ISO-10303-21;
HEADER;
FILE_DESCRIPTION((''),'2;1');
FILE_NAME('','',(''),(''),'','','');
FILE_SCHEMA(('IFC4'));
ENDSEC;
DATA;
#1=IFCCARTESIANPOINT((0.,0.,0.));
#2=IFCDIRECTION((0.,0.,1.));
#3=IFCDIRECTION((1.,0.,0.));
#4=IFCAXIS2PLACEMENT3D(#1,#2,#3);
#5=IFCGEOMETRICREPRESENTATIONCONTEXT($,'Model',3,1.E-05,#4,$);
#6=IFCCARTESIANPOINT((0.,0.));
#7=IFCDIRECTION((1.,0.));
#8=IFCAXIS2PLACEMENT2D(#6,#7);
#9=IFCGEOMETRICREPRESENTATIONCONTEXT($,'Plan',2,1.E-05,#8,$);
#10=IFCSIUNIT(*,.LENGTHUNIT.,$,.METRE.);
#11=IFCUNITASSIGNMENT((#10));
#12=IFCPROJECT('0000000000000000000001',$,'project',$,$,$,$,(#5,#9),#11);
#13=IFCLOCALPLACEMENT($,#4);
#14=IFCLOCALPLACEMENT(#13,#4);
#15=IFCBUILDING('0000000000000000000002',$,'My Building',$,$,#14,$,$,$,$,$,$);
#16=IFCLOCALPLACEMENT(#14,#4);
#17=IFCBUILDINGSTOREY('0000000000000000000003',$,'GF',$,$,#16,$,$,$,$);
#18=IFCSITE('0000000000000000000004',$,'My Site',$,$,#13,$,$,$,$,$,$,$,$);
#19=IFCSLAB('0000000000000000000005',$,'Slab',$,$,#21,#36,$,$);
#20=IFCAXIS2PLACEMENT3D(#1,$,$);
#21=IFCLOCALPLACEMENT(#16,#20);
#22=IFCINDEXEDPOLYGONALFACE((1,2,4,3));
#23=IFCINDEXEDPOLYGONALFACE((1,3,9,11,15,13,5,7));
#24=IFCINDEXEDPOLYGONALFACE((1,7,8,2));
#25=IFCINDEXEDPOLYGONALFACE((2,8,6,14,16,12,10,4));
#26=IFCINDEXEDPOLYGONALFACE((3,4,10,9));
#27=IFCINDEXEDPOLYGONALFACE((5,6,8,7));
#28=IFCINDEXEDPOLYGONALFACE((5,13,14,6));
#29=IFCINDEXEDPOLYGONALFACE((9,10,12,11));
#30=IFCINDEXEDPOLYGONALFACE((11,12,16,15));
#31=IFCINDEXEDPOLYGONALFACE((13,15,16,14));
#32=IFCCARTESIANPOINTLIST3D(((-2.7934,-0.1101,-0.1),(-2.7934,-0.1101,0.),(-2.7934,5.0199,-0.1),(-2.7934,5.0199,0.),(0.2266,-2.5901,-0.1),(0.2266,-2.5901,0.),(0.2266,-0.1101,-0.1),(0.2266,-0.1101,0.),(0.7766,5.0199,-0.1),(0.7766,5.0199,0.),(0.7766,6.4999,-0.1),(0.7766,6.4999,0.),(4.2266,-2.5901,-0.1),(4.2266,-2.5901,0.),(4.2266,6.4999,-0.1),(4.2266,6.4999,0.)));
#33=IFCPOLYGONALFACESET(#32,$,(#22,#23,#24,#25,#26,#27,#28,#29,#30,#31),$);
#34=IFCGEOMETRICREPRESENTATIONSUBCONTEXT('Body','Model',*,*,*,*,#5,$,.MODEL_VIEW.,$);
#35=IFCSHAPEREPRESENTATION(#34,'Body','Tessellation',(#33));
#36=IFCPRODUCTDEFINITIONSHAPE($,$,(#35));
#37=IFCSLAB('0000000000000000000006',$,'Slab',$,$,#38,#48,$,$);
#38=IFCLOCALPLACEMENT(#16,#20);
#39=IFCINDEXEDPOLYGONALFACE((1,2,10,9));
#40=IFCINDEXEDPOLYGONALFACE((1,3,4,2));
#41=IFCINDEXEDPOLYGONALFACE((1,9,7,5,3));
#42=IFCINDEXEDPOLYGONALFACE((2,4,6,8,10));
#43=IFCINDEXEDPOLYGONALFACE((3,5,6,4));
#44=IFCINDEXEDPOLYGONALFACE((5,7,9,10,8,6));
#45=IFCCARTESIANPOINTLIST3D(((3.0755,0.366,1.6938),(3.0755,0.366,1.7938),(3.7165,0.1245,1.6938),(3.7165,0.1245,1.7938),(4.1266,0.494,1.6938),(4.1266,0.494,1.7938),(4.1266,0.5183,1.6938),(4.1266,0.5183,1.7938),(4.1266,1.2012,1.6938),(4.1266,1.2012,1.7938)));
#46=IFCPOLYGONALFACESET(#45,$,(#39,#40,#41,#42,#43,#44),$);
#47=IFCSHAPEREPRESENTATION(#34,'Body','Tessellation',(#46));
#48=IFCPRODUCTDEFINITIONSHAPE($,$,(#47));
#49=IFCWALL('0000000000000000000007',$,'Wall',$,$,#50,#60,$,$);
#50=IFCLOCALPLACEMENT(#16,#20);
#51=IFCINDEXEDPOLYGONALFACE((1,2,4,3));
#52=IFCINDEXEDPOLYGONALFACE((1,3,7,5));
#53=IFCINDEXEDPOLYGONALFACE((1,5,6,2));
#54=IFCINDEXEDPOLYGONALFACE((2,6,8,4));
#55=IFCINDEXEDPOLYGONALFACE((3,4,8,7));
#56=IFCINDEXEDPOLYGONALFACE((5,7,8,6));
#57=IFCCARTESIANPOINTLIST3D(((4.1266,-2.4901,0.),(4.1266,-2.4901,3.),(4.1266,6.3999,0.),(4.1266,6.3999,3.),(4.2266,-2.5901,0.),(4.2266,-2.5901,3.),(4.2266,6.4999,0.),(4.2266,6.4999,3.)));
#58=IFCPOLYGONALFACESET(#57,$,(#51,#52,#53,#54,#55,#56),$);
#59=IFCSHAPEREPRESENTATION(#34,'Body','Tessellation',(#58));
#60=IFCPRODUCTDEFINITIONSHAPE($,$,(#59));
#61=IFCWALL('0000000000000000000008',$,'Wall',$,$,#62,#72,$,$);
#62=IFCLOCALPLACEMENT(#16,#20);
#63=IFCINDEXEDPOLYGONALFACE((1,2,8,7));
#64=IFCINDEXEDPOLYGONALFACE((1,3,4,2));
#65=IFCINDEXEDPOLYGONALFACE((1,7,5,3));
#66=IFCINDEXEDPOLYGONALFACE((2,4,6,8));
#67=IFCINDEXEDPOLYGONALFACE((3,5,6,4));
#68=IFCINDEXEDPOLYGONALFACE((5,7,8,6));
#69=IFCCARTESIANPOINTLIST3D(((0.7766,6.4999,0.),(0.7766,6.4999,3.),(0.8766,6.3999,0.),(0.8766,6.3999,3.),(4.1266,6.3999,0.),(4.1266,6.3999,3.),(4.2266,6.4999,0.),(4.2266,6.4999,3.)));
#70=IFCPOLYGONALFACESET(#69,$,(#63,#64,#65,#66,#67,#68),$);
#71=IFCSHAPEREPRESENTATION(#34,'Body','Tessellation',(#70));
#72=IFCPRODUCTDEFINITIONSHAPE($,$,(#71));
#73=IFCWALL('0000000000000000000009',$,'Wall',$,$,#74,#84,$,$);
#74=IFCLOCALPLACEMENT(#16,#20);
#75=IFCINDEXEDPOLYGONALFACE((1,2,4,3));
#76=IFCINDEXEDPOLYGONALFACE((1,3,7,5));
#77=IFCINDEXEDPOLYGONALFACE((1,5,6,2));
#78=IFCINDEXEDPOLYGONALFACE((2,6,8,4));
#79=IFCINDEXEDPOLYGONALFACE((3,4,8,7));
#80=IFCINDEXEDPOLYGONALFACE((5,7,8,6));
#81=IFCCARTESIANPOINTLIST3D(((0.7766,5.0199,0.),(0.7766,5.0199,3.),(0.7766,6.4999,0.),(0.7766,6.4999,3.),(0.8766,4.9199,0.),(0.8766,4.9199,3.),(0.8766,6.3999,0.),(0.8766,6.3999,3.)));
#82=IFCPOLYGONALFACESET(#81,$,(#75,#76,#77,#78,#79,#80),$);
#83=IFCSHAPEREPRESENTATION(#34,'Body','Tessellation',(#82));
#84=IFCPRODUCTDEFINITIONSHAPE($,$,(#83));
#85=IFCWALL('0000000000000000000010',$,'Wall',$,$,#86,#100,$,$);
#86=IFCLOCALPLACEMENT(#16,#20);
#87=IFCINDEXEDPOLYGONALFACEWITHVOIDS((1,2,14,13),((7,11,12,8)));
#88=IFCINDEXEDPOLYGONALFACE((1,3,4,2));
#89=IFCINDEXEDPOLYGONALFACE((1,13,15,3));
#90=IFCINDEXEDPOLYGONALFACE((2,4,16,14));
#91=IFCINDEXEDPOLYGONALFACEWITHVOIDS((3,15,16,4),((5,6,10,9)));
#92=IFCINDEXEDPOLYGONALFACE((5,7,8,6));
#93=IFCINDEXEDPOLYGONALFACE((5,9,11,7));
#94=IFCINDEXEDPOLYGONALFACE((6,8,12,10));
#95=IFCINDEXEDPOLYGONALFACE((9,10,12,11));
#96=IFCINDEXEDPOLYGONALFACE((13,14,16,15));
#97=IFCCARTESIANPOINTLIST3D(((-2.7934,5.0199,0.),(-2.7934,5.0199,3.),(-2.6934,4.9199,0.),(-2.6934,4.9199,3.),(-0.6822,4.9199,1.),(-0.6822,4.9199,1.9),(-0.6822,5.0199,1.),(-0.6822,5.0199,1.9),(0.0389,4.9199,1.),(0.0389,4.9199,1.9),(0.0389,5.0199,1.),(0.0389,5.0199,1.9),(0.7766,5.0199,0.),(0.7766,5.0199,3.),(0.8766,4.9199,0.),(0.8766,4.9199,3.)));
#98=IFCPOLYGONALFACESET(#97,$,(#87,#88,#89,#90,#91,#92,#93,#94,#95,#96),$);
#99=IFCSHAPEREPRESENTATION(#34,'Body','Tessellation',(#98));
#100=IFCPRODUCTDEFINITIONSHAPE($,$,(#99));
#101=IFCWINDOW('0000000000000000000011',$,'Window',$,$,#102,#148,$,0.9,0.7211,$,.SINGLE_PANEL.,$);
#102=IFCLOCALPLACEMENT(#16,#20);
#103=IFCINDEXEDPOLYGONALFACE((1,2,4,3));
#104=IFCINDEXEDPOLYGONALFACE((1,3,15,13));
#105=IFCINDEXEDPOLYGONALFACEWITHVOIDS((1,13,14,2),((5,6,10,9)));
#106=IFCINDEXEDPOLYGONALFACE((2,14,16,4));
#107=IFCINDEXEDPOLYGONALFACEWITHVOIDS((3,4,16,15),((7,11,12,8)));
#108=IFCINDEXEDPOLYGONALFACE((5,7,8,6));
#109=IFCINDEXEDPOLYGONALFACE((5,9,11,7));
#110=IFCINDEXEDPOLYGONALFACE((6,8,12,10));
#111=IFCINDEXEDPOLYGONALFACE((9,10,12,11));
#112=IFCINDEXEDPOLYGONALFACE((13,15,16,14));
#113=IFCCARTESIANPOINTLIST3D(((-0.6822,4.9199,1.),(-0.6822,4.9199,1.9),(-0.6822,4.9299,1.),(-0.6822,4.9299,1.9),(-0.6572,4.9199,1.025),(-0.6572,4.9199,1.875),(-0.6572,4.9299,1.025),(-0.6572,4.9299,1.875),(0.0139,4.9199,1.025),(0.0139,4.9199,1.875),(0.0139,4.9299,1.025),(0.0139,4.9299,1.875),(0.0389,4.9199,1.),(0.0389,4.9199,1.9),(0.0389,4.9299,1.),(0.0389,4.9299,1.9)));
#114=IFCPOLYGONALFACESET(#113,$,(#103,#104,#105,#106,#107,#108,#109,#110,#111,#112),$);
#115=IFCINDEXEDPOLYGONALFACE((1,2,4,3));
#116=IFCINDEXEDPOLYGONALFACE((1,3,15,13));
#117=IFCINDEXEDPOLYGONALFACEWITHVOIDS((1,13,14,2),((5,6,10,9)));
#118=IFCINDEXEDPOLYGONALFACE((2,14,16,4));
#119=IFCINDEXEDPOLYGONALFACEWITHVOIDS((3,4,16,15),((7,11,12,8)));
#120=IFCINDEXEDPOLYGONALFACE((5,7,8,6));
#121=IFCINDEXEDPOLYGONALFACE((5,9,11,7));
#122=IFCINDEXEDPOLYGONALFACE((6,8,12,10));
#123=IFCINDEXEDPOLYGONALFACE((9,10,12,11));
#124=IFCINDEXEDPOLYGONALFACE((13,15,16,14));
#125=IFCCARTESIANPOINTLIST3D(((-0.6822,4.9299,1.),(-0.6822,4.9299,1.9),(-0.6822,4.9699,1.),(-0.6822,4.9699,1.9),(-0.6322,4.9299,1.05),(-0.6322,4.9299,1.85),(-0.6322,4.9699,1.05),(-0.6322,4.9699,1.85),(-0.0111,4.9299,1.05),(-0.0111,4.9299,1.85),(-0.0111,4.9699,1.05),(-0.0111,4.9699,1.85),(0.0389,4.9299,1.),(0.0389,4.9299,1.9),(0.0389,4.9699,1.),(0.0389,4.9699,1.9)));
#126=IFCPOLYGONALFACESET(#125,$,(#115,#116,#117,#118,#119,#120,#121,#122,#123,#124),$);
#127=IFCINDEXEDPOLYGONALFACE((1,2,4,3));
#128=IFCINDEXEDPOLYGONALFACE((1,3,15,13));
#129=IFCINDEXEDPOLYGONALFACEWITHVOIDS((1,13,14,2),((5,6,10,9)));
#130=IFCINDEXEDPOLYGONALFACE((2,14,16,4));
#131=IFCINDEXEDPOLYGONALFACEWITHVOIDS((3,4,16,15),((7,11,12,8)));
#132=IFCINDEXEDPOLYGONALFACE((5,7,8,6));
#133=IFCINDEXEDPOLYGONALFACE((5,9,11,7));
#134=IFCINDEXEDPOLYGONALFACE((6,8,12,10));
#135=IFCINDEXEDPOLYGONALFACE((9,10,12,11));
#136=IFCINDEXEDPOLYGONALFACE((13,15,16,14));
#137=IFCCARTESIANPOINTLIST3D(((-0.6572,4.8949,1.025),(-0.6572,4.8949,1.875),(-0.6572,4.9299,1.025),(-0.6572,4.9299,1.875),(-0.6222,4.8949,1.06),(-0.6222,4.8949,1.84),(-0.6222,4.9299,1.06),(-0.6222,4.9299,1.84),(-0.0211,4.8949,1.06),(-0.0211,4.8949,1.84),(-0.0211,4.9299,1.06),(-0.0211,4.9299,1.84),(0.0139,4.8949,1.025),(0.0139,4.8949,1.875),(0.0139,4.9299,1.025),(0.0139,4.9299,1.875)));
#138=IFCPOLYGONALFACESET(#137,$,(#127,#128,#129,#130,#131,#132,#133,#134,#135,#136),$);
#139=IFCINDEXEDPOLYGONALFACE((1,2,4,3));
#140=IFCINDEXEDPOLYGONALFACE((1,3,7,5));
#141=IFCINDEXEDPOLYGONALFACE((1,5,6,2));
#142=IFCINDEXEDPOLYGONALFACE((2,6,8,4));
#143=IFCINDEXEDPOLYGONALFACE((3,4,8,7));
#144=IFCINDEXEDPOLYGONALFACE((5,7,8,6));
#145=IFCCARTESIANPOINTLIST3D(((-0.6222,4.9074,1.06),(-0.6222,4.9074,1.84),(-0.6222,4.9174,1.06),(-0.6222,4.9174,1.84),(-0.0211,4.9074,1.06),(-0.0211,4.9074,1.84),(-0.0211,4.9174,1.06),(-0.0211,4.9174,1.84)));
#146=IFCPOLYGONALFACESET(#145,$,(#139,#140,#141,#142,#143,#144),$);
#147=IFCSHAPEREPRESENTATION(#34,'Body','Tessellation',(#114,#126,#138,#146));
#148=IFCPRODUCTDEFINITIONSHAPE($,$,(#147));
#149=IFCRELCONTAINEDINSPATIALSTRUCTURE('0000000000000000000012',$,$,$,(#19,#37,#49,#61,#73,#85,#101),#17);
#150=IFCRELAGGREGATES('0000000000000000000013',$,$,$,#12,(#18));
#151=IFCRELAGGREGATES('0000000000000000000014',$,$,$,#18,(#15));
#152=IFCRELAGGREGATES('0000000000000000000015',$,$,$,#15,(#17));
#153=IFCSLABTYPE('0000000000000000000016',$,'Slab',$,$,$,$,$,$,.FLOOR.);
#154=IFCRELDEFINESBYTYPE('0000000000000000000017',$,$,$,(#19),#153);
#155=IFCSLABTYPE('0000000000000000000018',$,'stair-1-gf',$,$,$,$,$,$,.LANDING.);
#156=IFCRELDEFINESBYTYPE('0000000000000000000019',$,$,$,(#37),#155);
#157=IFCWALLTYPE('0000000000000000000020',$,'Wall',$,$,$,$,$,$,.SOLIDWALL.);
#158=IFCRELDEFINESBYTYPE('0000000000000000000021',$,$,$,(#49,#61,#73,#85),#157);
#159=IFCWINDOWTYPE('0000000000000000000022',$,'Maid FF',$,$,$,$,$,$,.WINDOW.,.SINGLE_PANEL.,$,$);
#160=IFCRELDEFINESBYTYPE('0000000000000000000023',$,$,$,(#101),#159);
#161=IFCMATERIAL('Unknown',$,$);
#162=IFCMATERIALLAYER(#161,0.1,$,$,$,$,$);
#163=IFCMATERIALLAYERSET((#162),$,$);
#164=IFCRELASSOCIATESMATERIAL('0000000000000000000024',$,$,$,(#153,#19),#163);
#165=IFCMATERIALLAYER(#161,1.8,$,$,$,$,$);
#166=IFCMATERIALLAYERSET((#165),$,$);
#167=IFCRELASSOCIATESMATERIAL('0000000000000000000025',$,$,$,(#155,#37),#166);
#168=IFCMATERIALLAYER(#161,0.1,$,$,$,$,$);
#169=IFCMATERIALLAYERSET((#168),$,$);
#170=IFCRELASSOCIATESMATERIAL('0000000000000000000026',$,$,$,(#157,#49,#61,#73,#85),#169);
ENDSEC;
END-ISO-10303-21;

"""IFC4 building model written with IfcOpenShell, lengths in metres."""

from ifc_helpers import new_model, entity, si_unit, frame, origin_with_axes, origin_2d_with_axis, place, context, subcontext, project, spatial, line, indexed_curve, outline, extrude, shape, source, transform, mapped, material, layer, layer_set, layer_usage, type_object, type_shapes, element, fill, save


model = new_model("IFC4")

# Units and contexts
model_context = context("Model", 3, precision=1e-05, world=origin_with_axes())
plan_context = context("Plan", 2, precision=1e-05, world=origin_2d_with_axis())
body_context_1 = subcontext(model_context, "Body", "Model", "MODEL_VIEW")
body_context_2 = subcontext(plan_context, "Body", "Plan", "PLAN_VIEW")
ifc_project = project(units=[si_unit("LENGTHUNIT", "METRE")], contexts=[model_context, plan_context])

# Site, building, storey
site_placement = place(None, origin_with_axes())
site = spatial("IfcSite", under=ifc_project, at=site_placement, Name="My Site")
building_placement = place(site_placement, origin_with_axes())
building = spatial("IfcBuilding", under=site, at=building_placement, Name="My Building")
storey_placement = place(building_placement, origin_with_axes())
storey = spatial("IfcBuildingStorey", under=building, at=storey_placement, Name="GF")

# Slabs
ifc_material_1 = material(Name="Unknown")
ifc_layer_1 = layer(ifc_material_1, 0.1)
ifc_layer_set_1 = layer_set([ifc_layer_1])
ifc_layer_usage_1 = layer_usage(ifc_layer_set_1, "AXIS3", "POSITIVE", -0.1)
slab_type_1 = type_object("IfcSlabType", Name="Slab", PredefinedType="FLOOR", material=ifc_layer_set_1)
slab_1_placement = place(storey_placement, frame((4.2266, -2.5901, 0.0), z_axis=(0.0, 0.0, 1.0), x_axis=(1.0, 0.0, 0.0)))
element("IfcSlab", 1, at=slab_1_placement, inside=storey, type_object=slab_type_1, material=ifc_layer_usage_1, Name="Slab", context=body_context_1, shape_type="SweptSolid", body=[
    extrude(outline(indexed_curve([(0.0, 0.0), (0.0, 9.09), (-3.45, 9.09), (-3.45, 7.61), (-7.02, 7.61), (-7.02, 2.48), (-4.0, 2.48), (-4.0, 0.0), (0.0, 0.0)])), frame((0.0, 0.0, -0.1), z_axis=(0.0, 0.0, 1.0), x_axis=(1.0, 0.0, 0.0)), (0.0, 0.0, 1.0), 0.1),
])
ifc_layer_2 = layer(ifc_material_1, 1.8)
ifc_layer_set_2 = layer_set([ifc_layer_2])
ifc_layer_usage_2 = layer_usage(ifc_layer_set_2, "AXIS3", "POSITIVE", -0.1)
slab_type_2 = type_object("IfcSlabType", Name="stair-1-gf", PredefinedType="LANDING", material=ifc_layer_set_2)
slab_2_placement = place(storey_placement, frame((4.1266, 0.5183, 1.7938), z_axis=(0.0, 0.0, 1.0), x_axis=(1.0, 0.0, 0.0)))
element("IfcSlab", 2, at=slab_2_placement, inside=storey, type_object=slab_type_2, material=ifc_layer_usage_2, Name="Slab", context=body_context_1, shape_type="SweptSolid", body=[
    extrude(outline(indexed_curve([(0.0, 0.0), (0.0, 0.6829), (-1.0511, -0.1523), (-0.4101, -0.3938), (0.0, -0.0244), (0.0, 0.0)])), frame((0.0, 0.0, -0.1), z_axis=(0.0, 0.0, 1.0), x_axis=(1.0, 0.0, 0.0)), (0.0, 0.0, 1.0), 0.1),
])

# Shared definitions
ifc_layer_3 = layer(ifc_material_1, 0.1)
ifc_layer_set_3 = layer_set([ifc_layer_3])
wall_type = type_object("IfcWallType", Name="Wall", PredefinedType="SOLIDWALL", material=ifc_layer_set_3)

# Walls
ifc_layer_usage_3 = layer_usage(ifc_layer_set_3, "AXIS2", "POSITIVE", 0.0)
wall_1_placement = place(storey_placement, frame((4.2266, -2.5901, 0.0), z_axis=(0.0, 0.0, 1.0), x_axis=(0.0, 1.0, 0.0)))
element("IfcWall", 3, at=wall_1_placement, inside=storey, type_object=wall_type, material=ifc_layer_usage_3, Name="Wall", context=body_context_1, shape_type="SweptSolid", body=[
    extrude(outline(indexed_curve([(0.0, 0.0), (0.1, 0.1), (8.99, 0.1), (9.09, 0.0)], segments=[line(1, 2, 3, 4, 1)])), origin_with_axes(), (0.0, 0.0, 1.0), 3.0),
])
ifc_layer_usage_4 = layer_usage(ifc_layer_set_3, "AXIS2", "POSITIVE", 0.0)
wall_2_placement = place(storey_placement, frame((4.2266, 6.4999, 0.0), z_axis=(0.0, 0.0, 1.0), x_axis=(-1.0, 0.0, 0.0)))
element("IfcWall", 4, at=wall_2_placement, inside=storey, type_object=wall_type, material=ifc_layer_usage_4, Name="Wall", context=body_context_1, shape_type="SweptSolid", body=[
    extrude(outline(indexed_curve([(0.0, 0.0), (0.1, 0.1), (3.35, 0.1), (3.45, 0.0)], segments=[line(1, 2, 3, 4, 1)])), origin_with_axes(), (0.0, 0.0, 1.0), 3.0),
])
ifc_layer_usage_5 = layer_usage(ifc_layer_set_3, "AXIS2", "POSITIVE", 0.0)
wall_3_placement = place(storey_placement, frame((0.7766, 6.4999, 0.0), z_axis=(0.0, 0.0, 1.0), x_axis=(0.0, -1.0, 0.0)))
element("IfcWall", 5, at=wall_3_placement, inside=storey, type_object=wall_type, material=ifc_layer_usage_5, Name="Wall", context=body_context_1, shape_type="SweptSolid", body=[
    extrude(outline(indexed_curve([(0.0, 0.0), (0.1, 0.1), (1.58, 0.1), (1.48, 0.0)], segments=[line(1, 2, 3, 4, 1)])), origin_with_axes(), (0.0, 0.0, 1.0), 3.0),
])

# Wall, opening, window
ifc_layer_usage_6 = layer_usage(ifc_layer_set_3, "AXIS2", "POSITIVE", 0.0)
wall_4_placement = place(storey_placement, frame((0.7766, 5.0199, 0.0), z_axis=(0.0, 0.0, 1.0), x_axis=(-1.0, 0.0, 0.0)))
wall_4 = element("IfcWall", 6, at=wall_4_placement, inside=storey, type_object=wall_type, material=ifc_layer_usage_6, Name="Wall", context=body_context_1, shape_type="SweptSolid", body=[
    extrude(outline(indexed_curve([(0.0, 0.0), (-0.1, 0.1), (3.47, 0.1), (3.57, 0.0)], segments=[line(1, 2, 3, 4, 1)])), origin_with_axes(), (0.0, 0.0, 1.0), 3.0),
])
shared_shape_1 = source(origin_with_axes(), body_context_1, "Body", "SweptSolid", [
    extrude(outline(indexed_curve([(0.0, 0.0), (0.7211, 0.0), (0.7211, 0.9), (0.0, 0.9)], segments=[line(1, 2, 3, 4, 1)])), frame((0.0, -0.6, 0.0), z_axis=(0.0, -1.0, 0.0), x_axis=(1.0, 0.0, 0.0)), (0.0, 0.0, -1.0), 1.2),
])
opening_1_placement = place(wall_4_placement, frame((0.7377, 0.0, 1.0), z_axis=(0.0, 0.0, 1.0), x_axis=(1.0, 0.0, 0.0)))
opening_1 = element("IfcOpeningElement", 7, at=opening_1_placement, cuts=wall_4, PredefinedType="OPENING", context=body_context_1, shape_type="MappedRepresentation", body=[
    mapped(shared_shape_1, transform((0.0, 0.0, 0.0), x_axis=(1.0, 0.0, 0.0), y_axis=(0.0, 1.0, 0.0), z_axis=(0.0, 0.0, 1.0), scale=1.0)),
])
window_type_1 = type_object("IfcWindowType", Name="Maid FF", PartitioningType="SINGLE_PANEL", PredefinedType="WINDOW")
shared_shape_2 = source(origin_with_axes(), body_context_1, "Body", "SweptSolid", [
    extrude(outline(indexed_curve([(0.0, 0.0), (0.7211, 0.0), (0.7211, 0.9), (0.0, 0.9)], segments=[line(1, 2, 3, 4, 1)]), holes=[indexed_curve([(0.025, 0.025), (0.6961, 0.025), (0.6961, 0.875), (0.025, 0.875)], segments=[line(1, 2, 3, 4, 1)])]), frame((0.0, 0.09, 0.0), z_axis=(0.0, -1.0, 0.0), x_axis=(1.0, 0.0, 0.0)), (0.0, 0.0, -1.0), 0.01),
    extrude(outline(indexed_curve([(0.0, 0.0), (0.7211, 0.0), (0.7211, 0.9), (0.0, 0.9)], segments=[line(1, 2, 3, 4, 1)]), holes=[indexed_curve([(0.05, 0.05), (0.6711, 0.05), (0.6711, 0.85), (0.05, 0.85)], segments=[line(1, 2, 3, 4, 1)])]), frame((0.0, 0.05, 0.0), z_axis=(0.0, -1.0, 0.0), x_axis=(1.0, 0.0, 0.0)), (0.0, 0.0, -1.0), 0.04),
    extrude(outline(indexed_curve([(0.0, 0.0), (0.6711, 0.0), (0.6711, 0.85), (0.0, 0.85)], segments=[line(1, 2, 3, 4, 1)]), holes=[indexed_curve([(0.035, 0.035), (0.6361, 0.035), (0.6361, 0.815), (0.035, 0.815)], segments=[line(1, 2, 3, 4, 1)])]), frame((0.025, 0.09, 0.025), z_axis=(0.0, -1.0, 0.0), x_axis=(1.0, 0.0, 0.0)), (0.0, 0.0, -1.0), 0.035),
    extrude(outline(indexed_curve([(0.035, 0.035), (0.6361, 0.035), (0.6361, 0.815), (0.035, 0.815)], segments=[line(1, 2, 3, 4, 1)])), frame((0.025, 0.1025, 0.025), z_axis=(0.0, -1.0, 0.0), x_axis=(1.0, 0.0, 0.0)), (0.0, 0.0, -1.0), 0.01),
])
shared_shape_3 = source(origin_with_axes(), body_context_2, "Body", "Curve2D", [
    entity("IfcIndexedPolyCurve", entity("IfcCartesianPointList2D", [[0.05, 0.05], [0.6711, 0.05]])),
    entity("IfcIndexedPolyCurve", entity("IfcCartesianPointList2D", [[0.0, 0.1], [0.025, 0.1], [0.025, 0.09], [0.05, 0.09], [0.05, 0.05], [0.0, 0.05]]), [entity("IfcLineIndex", [1, 2, 3, 4, 5, 6, 1])]),
    entity("IfcIndexedPolyCurve", entity("IfcCartesianPointList2D", [[0.7211, 0.1], [0.6961, 0.1], [0.6961, 0.09], [0.6711, 0.09], [0.6711, 0.05], [0.7211, 0.05]]), [entity("IfcLineIndex", [1, 2, 3, 4, 5, 6, 1])]),
    entity("IfcIndexedPolyCurve", entity("IfcCartesianPointList2D", [[0.025, 0.09], [0.06, 0.09], [0.06, 0.125], [0.025, 0.125]]), [entity("IfcLineIndex", [1, 2, 3, 4, 1])]),
    entity("IfcIndexedPolyCurve", entity("IfcCartesianPointList2D", [[0.6961, 0.09], [0.6611, 0.09], [0.6611, 0.125], [0.6961, 0.125]]), [entity("IfcLineIndex", [1, 2, 3, 4, 1])]),
    entity("IfcIndexedPolyCurve", entity("IfcCartesianPointList2D", [[0.06, 0.09], [0.6611, 0.09]])),
    entity("IfcIndexedPolyCurve", entity("IfcCartesianPointList2D", [[0.06, 0.125], [0.6611, 0.125]])),
    entity("IfcIndexedPolyCurve", entity("IfcCartesianPointList2D", [[0.06, 0.1075], [0.6611, 0.1075]])),
])
type_shapes(window_type_1, [shared_shape_2, shared_shape_3])
window_1_placement = place(opening_1_placement, frame((0.0, 0.0, 0.0), z_axis=(0.0, 0.0, 1.0), x_axis=(1.0, 0.0, 0.0)))
window_1 = element("IfcWindow", 8, at=window_1_placement, inside=storey, type_object=window_type_1, Name="Window", OverallHeight=0.9, OverallWidth=0.7211, PartitioningType="SINGLE_PANEL", shapes=[
    shape(body_context_1, "Body", "MappedRepresentation", [mapped(shared_shape_2, transform((0.0, 0.0, 0.0), x_axis=(1.0, 0.0, 0.0), y_axis=(0.0, 1.0, 0.0), z_axis=(0.0, 0.0, 1.0), scale=1.0))]),
    shape(body_context_2, "Body", "MappedRepresentation", [mapped(shared_shape_3, transform((0.0, 0.0, 0.0), x_axis=(1.0, 0.0, 0.0), y_axis=(0.0, 1.0, 0.0), z_axis=(0.0, 0.0, 1.0), scale=1.0))]),
])
fill(opening_1, window_1)

save(model, "model.ifc")
